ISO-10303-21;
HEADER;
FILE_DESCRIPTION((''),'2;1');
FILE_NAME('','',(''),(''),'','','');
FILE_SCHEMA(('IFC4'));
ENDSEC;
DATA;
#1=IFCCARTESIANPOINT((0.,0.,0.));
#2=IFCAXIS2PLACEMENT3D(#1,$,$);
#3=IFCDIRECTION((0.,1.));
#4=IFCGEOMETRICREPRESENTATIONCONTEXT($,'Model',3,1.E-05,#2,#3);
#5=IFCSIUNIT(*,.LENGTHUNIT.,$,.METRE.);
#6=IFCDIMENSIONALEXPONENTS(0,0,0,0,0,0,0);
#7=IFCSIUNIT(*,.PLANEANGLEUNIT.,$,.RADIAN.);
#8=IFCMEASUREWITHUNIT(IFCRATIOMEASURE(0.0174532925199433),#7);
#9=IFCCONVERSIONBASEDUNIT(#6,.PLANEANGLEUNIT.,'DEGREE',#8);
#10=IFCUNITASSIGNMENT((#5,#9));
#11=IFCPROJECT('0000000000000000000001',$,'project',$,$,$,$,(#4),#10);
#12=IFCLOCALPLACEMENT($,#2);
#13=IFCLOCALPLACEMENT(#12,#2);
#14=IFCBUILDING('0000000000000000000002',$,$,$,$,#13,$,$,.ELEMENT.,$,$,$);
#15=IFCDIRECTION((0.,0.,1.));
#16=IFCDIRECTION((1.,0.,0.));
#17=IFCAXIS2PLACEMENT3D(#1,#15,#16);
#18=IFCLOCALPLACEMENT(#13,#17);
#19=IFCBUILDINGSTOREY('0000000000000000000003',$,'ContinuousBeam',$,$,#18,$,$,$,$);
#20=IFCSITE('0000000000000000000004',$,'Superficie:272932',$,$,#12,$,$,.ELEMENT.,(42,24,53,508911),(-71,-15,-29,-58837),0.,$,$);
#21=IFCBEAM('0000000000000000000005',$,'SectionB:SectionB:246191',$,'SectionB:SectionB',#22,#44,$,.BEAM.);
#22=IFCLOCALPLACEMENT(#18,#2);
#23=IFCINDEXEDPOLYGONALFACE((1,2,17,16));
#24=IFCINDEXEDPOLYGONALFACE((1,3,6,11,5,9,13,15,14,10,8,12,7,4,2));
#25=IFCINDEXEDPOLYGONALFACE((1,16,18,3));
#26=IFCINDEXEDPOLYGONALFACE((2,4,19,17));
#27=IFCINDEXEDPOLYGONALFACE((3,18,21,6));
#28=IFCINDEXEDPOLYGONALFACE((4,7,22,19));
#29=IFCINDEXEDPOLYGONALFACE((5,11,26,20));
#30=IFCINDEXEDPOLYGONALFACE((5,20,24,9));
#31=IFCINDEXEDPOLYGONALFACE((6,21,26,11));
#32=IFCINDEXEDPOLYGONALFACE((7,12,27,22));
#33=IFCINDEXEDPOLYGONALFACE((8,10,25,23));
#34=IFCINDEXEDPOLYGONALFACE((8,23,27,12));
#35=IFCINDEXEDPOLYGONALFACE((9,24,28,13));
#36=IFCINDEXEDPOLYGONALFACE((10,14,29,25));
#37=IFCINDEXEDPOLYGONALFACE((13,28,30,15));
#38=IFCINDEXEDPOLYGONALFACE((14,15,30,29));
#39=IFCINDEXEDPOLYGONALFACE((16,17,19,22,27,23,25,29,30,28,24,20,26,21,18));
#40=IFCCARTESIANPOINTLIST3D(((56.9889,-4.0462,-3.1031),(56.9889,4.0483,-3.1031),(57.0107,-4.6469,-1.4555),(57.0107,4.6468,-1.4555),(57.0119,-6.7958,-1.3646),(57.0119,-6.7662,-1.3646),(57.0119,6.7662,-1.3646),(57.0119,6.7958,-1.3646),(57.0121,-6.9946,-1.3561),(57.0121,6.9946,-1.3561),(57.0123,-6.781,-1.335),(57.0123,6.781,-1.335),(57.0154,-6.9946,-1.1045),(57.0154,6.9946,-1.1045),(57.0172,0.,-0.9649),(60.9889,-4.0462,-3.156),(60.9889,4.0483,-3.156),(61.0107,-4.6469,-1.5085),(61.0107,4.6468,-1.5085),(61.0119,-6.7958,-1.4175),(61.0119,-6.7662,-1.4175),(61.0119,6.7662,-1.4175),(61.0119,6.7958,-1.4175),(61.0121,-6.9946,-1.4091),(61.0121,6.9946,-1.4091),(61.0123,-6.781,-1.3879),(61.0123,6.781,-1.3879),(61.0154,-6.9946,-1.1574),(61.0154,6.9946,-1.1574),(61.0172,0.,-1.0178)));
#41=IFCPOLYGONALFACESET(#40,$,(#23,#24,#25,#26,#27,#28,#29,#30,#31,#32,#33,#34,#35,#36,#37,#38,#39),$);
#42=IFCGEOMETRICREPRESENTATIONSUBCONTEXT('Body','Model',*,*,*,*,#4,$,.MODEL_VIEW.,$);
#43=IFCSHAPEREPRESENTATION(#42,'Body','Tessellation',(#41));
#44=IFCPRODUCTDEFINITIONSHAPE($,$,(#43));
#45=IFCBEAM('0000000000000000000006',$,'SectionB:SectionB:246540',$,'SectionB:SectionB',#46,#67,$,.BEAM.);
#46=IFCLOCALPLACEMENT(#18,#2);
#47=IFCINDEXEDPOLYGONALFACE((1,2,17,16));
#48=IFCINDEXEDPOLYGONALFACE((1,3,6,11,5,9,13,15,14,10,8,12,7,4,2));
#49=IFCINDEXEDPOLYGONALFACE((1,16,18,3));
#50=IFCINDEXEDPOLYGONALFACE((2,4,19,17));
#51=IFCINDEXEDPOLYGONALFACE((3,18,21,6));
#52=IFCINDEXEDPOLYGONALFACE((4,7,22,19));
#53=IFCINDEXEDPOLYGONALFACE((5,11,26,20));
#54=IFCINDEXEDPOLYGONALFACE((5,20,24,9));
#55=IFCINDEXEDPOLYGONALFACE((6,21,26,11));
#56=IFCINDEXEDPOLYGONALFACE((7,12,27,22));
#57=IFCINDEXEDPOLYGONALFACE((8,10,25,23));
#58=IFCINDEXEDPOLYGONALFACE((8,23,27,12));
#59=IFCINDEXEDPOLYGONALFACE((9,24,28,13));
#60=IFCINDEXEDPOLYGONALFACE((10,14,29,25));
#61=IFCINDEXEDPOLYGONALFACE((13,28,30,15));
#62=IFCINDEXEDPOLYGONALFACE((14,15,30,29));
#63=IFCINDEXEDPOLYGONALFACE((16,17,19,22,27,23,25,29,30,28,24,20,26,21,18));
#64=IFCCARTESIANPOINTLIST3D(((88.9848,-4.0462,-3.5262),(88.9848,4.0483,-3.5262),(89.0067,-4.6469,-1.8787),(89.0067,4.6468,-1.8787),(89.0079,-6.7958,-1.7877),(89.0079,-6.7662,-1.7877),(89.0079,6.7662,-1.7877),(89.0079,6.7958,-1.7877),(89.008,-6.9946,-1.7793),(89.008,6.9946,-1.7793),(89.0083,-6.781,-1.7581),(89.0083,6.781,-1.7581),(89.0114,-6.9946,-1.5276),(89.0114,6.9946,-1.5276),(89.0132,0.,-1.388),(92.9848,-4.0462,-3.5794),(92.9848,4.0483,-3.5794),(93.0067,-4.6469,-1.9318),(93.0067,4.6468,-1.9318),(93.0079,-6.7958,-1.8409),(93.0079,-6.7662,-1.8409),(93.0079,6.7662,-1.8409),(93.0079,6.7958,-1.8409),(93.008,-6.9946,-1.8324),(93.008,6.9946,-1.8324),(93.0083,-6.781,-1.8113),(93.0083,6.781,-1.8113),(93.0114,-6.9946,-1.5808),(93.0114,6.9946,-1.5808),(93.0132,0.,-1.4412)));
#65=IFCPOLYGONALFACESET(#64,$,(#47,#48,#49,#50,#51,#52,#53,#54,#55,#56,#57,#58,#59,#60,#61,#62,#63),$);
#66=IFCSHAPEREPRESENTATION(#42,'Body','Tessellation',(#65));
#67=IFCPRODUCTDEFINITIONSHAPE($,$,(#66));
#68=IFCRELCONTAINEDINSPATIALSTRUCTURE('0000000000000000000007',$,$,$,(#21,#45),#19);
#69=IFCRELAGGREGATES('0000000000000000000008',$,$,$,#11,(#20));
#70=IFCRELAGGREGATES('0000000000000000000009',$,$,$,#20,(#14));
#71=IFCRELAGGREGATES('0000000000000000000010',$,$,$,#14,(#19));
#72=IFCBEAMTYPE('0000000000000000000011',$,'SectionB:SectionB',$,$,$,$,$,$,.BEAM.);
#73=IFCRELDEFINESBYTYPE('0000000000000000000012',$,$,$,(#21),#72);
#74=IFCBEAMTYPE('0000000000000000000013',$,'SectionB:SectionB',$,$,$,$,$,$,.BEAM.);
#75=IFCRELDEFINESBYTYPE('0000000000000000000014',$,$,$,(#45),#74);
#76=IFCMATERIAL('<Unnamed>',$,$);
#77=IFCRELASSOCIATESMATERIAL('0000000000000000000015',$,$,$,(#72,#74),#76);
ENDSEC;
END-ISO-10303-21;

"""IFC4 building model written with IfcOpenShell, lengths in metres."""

from ifc_helpers import new_model, entity, si_unit, converted_unit, direction, frame, origin, origin_with_axes, place, context, subcontext, project, spatial, indexed_curve, outline, extrude, source, transform, mapped, material, type_object, type_shapes, element, save


model = new_model("IFC4")

# Units and contexts
model_context = context("Model", 3, precision=1e-05, world=origin(), true_north=direction((0.0, 1.0)))
body_context = subcontext(model_context, "Body", "Model", "MODEL_VIEW")
ifc_project = project(units=[si_unit("LENGTHUNIT", "METRE"), converted_unit("PLANEANGLEUNIT", "DEGREE", entity("IfcRatioMeasure", 0.0174532925199433), si_unit("PLANEANGLEUNIT", "RADIAN"), dimensions=[0, 0, 0, 0, 0, 0, 0])], contexts=[model_context])

# Site, building, storey
site_placement = place(None, origin())
site = spatial("IfcSite", under=ifc_project, at=site_placement, Name="Superficie:272932", CompositionType="ELEMENT", RefLatitude=(42, 24, 53, 508911), RefLongitude=(-71, -15, -29, -58837), RefElevation=0.0)
building_placement = place(site_placement, origin())
building = spatial("IfcBuilding", under=site, at=building_placement, CompositionType="ELEMENT")
storey_placement = place(building_placement, origin_with_axes())
storey = spatial("IfcBuildingStorey", under=building, at=storey_placement, Name="ContinuousBeam")

# Beams
ifc_material = material(Name="<Unnamed>")
beam_type_1 = type_object("IfcBeamType", Name="SectionB:SectionB", PredefinedType="BEAM", material=ifc_material)
shared_shape_1 = source(origin(), body_context, "Body", "SweptSolid", [
    extrude(outline(indexed_curve([(-4.0463, -1.5611), (4.0481, -1.5611), (4.6467, 0.0866), (6.766, 0.1775), (6.7809, 0.2071), (6.7957, 0.1775), (6.9945, 0.186), (6.9945, 0.4377), (-0.0001, 0.5773), (-6.9948, 0.4377), (-6.9948, 0.186), (-6.7959, 0.1775), (-6.7811, 0.2071), (-6.7663, 0.1775), (-4.647, 0.0866), (-4.0463, -1.5611)], self_intersect=False)), frame((57.0096, 0.0001, -1.5421), z_axis=(0.999912, 0.0, -0.013229), x_axis=(0.0, 1.0, 0.0)), (0.0, 0.0, 1.0), 4.0004),
])
type_shapes(beam_type_1, [shared_shape_1])
beam_1_placement = place(storey_placement, origin_with_axes())
element("IfcBeam", 1, at=beam_1_placement, inside=storey, type_object=beam_type_1, Name="SectionB:SectionB:246191", ObjectType="SectionB:SectionB", PredefinedType="BEAM", context=body_context, shape_type="MappedRepresentation", body=[
    mapped(shared_shape_1, transform((0.0, 0.0, 0.0), scale=1.0)),
])
beam_type_2 = type_object("IfcBeamType", Name="SectionB:SectionB", PredefinedType="BEAM", material=ifc_material)
shared_shape_2 = source(origin(), body_context, "Body", "SweptSolid", [
    extrude(outline(indexed_curve([(-4.0463, -1.5611), (4.0481, -1.5611), (4.6467, 0.0866), (6.766, 0.1775), (6.7809, 0.2071), (6.7957, 0.1775), (6.9945, 0.186), (6.9945, 0.4377), (-0.0001, 0.5773), (-6.9948, 0.4377), (-6.9948, 0.186), (-6.7959, 0.1775), (-6.7811, 0.2071), (-6.7663, 0.1775), (-4.647, 0.0866), (-4.0463, -1.5611)], self_intersect=False)), frame((89.0056, 0.0001, -1.9652), z_axis=(0.999912, 0.0, -0.01329), x_axis=(0.0, 1.0, 0.0)), (0.0, 0.0, 1.0), 4.0004),
])
type_shapes(beam_type_2, [shared_shape_2])
beam_2_placement = place(storey_placement, origin_with_axes())
element("IfcBeam", 2, at=beam_2_placement, inside=storey, type_object=beam_type_2, Name="SectionB:SectionB:246540", ObjectType="SectionB:SectionB", PredefinedType="BEAM", context=body_context, shape_type="MappedRepresentation", body=[
    mapped(shared_shape_2, transform((0.0, 0.0, 0.0), scale=1.0)),
])

save(model, "model.ifc")
